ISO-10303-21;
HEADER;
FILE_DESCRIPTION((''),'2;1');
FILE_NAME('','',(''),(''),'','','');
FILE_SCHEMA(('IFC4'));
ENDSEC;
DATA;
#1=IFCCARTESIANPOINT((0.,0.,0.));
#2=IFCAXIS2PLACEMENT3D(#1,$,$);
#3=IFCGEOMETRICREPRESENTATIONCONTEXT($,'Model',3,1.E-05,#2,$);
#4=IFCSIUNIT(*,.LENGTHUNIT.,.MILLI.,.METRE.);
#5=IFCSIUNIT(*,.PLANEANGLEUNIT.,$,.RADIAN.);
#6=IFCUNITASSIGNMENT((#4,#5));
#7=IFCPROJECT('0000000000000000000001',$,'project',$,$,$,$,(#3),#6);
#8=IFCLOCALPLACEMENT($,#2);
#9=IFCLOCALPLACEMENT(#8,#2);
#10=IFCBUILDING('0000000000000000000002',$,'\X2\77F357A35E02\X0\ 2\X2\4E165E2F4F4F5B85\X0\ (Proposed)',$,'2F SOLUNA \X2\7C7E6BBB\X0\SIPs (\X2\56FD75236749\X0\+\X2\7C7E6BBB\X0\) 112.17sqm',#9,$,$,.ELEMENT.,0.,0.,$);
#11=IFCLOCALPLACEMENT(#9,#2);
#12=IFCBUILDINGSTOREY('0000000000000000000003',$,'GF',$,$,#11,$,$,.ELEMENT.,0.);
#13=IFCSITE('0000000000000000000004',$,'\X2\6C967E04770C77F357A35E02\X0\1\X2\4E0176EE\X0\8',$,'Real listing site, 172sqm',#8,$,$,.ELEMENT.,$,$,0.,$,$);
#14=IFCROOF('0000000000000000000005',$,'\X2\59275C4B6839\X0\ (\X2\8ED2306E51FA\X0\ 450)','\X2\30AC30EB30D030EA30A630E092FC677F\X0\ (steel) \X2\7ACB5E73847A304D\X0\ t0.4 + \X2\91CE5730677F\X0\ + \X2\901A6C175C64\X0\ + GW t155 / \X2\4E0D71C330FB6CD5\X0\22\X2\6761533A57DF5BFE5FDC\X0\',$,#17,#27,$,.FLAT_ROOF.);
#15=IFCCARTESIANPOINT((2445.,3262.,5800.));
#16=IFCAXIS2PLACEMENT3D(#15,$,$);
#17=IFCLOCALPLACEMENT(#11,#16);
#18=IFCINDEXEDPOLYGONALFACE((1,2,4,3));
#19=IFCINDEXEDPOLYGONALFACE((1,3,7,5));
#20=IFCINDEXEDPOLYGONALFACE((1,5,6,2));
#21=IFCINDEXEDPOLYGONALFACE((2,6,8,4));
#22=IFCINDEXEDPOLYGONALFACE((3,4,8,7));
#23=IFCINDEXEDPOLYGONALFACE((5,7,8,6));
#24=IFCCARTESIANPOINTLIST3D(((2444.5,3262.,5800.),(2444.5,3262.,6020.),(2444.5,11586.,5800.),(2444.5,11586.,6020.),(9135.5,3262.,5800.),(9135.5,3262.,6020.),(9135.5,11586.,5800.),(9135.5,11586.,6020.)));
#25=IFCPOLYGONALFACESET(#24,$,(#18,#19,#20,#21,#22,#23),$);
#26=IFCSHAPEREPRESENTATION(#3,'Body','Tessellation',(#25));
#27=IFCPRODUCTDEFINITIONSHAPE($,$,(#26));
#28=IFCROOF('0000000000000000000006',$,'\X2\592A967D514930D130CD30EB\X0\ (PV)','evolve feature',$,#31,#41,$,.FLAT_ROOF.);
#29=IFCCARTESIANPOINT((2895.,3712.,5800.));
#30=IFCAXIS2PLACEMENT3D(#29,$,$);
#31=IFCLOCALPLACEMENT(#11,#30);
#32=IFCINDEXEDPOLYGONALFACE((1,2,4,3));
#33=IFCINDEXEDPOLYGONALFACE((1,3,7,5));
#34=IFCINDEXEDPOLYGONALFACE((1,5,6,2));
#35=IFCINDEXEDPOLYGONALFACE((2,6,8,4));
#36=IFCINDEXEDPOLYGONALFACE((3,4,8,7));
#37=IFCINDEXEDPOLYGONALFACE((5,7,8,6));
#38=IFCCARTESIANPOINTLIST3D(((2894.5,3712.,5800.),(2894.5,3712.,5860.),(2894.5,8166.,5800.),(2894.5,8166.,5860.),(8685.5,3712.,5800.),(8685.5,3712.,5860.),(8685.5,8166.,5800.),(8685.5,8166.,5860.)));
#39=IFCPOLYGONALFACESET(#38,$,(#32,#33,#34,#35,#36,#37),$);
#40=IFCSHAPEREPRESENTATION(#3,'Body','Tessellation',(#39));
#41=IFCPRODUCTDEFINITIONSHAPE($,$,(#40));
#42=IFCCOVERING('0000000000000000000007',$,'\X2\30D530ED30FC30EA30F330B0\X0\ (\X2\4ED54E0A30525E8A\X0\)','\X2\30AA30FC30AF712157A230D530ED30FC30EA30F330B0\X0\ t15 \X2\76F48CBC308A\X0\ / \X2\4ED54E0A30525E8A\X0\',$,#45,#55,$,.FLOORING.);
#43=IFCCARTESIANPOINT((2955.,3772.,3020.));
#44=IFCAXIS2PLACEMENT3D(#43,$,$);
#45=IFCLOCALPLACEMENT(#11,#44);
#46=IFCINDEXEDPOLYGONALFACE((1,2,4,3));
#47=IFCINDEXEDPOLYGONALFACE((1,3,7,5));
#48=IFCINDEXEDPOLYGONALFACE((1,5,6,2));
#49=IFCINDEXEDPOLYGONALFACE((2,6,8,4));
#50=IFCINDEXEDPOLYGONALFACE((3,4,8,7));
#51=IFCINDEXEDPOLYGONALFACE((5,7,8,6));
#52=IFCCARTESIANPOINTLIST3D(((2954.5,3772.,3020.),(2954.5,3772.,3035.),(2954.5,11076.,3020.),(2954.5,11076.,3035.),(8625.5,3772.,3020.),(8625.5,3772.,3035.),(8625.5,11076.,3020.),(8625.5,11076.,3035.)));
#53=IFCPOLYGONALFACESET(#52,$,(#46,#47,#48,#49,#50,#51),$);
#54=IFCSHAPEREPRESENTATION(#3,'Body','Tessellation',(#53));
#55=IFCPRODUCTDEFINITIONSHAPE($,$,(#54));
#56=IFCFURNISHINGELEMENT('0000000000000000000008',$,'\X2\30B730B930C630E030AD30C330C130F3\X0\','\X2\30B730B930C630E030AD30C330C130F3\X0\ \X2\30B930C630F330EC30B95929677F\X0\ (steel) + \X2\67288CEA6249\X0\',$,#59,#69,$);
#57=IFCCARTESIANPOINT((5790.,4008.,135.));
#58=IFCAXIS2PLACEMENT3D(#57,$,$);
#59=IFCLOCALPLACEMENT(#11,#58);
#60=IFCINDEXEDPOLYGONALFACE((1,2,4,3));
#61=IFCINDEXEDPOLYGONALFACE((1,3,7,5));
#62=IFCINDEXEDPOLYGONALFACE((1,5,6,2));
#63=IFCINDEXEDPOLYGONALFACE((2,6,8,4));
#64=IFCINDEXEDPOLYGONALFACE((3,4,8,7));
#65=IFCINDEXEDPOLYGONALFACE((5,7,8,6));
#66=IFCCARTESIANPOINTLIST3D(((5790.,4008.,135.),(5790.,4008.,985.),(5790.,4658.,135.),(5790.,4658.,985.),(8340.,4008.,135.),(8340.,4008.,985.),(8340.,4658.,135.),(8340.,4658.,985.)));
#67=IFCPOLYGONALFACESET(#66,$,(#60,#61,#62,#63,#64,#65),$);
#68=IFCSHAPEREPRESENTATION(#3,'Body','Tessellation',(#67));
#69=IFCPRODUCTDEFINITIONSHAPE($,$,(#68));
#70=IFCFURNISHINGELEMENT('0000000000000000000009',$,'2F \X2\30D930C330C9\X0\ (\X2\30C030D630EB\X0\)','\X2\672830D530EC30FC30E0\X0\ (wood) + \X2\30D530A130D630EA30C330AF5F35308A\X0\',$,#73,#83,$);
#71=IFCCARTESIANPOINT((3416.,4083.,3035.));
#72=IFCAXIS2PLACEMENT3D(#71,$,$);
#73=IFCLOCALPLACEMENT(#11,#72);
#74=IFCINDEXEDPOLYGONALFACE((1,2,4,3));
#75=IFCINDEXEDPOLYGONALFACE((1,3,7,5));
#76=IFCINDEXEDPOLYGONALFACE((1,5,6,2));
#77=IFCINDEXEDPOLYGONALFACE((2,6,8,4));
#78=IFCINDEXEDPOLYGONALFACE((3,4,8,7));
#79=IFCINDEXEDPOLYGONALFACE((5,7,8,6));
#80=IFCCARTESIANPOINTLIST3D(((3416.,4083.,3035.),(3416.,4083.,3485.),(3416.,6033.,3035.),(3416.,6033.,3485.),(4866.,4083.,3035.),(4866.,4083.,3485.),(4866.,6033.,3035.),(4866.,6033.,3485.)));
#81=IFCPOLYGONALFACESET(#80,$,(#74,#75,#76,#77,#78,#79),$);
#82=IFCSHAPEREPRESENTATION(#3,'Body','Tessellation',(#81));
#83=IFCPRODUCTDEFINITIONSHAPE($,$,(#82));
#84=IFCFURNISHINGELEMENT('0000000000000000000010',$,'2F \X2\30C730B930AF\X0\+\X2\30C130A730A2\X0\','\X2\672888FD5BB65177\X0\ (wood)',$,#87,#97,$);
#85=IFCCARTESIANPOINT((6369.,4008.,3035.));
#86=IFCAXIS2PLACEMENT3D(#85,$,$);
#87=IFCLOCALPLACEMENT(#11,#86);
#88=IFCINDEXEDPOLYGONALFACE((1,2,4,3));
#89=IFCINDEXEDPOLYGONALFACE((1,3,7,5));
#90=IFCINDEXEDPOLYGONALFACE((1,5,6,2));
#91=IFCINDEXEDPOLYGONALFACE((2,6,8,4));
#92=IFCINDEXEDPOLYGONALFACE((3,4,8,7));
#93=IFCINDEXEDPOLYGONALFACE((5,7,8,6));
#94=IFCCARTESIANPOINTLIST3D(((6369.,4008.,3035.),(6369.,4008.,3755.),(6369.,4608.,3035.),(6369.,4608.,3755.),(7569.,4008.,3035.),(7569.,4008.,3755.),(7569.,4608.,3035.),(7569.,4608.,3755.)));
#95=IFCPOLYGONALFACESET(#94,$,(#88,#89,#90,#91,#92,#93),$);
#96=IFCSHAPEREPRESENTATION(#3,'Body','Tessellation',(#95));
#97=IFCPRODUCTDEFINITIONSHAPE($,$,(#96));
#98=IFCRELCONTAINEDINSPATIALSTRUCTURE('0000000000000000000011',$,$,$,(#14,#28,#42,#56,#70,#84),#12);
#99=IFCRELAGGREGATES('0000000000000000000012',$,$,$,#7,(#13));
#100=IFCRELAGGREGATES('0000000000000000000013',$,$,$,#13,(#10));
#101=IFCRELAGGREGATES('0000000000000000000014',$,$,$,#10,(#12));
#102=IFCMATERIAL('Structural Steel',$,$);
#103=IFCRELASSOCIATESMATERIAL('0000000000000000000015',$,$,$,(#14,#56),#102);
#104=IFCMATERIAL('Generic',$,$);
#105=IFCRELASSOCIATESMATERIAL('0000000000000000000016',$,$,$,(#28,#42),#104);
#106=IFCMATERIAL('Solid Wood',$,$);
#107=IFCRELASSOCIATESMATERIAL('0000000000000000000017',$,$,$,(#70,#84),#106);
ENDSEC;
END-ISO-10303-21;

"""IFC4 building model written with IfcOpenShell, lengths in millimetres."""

from ifc_helpers import new_model, si_unit, frame, frame_2d, origin, place, context, project, spatial, rectangle, extrude, material, element, save


model = new_model("IFC4")

# Units and contexts
model_context = context("Model", 3, precision=1e-05, world=origin())
ifc_project = project(units=[si_unit("LENGTHUNIT", "METRE", prefix="MILLI"), si_unit("PLANEANGLEUNIT", "RADIAN")], contexts=[model_context])

# Site, building, storey
site_placement = place(None, origin())
site = spatial("IfcSite", under=ifc_project, at=site_placement, Name="沖縄県石垣市1丁目8", ObjectType="Real listing site, 172sqm", CompositionType="ELEMENT", RefElevation=0.0)
building_placement = place(site_placement, origin())
building = spatial("IfcBuilding", under=site, at=building_placement, Name="石垣市 2世帯住宅 (Proposed)", ObjectType="2F SOLUNA 籾殻SIPs (国産杉+籾殻) 112.17sqm", CompositionType="ELEMENT", ElevationOfRefHeight=0.0, ElevationOfTerrain=0.0)
storey_placement = place(building_placement, origin())
storey = spatial("IfcBuildingStorey", under=building, at=storey_placement, Name="GF", CompositionType="ELEMENT", Elevation=0.0)

# Shared definitions
ifc_material_1 = material(Name="Solid Wood")

# Shared definitions
ifc_material_2 = material(Name="Generic")

# Roofs
ifc_material_3 = material(Name="Structural Steel")
roof_1_placement = place(storey_placement, frame((2445.0, 3262.0, 5800.0)))
element("IfcRoof", 1, at=roof_1_placement, inside=storey, material=ifc_material_3, Name="大屋根 (軒の出 450)", Description="ガルバリウム鋼板 (steel) 立平葺き t0.4 + 野地板 + 通気層 + GW t155 / 不燃・法22条区域対応", PredefinedType="FLAT_ROOF", context=model_context, shape_type="SweptSolid", body=[
    extrude(rectangle(XDim=6691.0, YDim=8324.0, at=frame_2d((3345.0, 4162.0))), frame((2445.0, 3262.0, 5800.0)), (0.0, 0.0, 1.0), 220.0),
])
roof_2_placement = place(storey_placement, frame((2895.0, 3712.0, 5800.0)))
element("IfcRoof", 2, at=roof_2_placement, inside=storey, material=ifc_material_2, Name="太陽光パネル (PV)", Description="evolve feature", PredefinedType="FLAT_ROOF", context=model_context, shape_type="SweptSolid", body=[
    extrude(rectangle(XDim=5791.0, YDim=4454.0, at=frame_2d((2895.0, 2227.0))), frame((2895.0, 3712.0, 5800.0)), (0.0, 0.0, 1.0), 60.0),
])

# Covering
covering_placement = place(storey_placement, frame((2955.0, 3772.0, 3020.0)))
element("IfcCovering", 3, at=covering_placement, inside=storey, material=ifc_material_2, Name="フローリング (仕上げ床)", Description="オーク無垢フローリング t15 直貼り / 仕上げ床", PredefinedType="FLOORING", context=model_context, shape_type="SweptSolid", body=[
    extrude(rectangle(XDim=5671.0, YDim=7304.0, at=frame_2d((2835.0, 3652.0))), frame((2955.0, 3772.0, 3020.0)), (0.0, 0.0, 1.0), 15.0),
])

# Furnishing elements
furnishing_1_placement = place(storey_placement, frame((5790.0, 4008.0, 135.0)))
element("IfcFurnishingElement", 4, at=furnishing_1_placement, inside=storey, material=ifc_material_3, Name="システムキッチン", Description="システムキッチン ステンレス天板 (steel) + 木質扉", context=model_context, shape_type="SweptSolid", body=[
    extrude(rectangle(XDim=2550.0, YDim=650.0, at=frame_2d((1275.0, 325.0))), frame((5790.0, 4008.0, 135.0)), (0.0, 0.0, 1.0), 850.0),
])
furnishing_2_placement = place(storey_placement, frame((3416.0, 4083.0, 3035.0)))
element("IfcFurnishingElement", 5, at=furnishing_2_placement, inside=storey, material=ifc_material_1, Name="2F ベッド (ダブル)", Description="木フレーム (wood) + ファブリック張り", context=model_context, shape_type="SweptSolid", body=[
    extrude(rectangle(XDim=1450.0, YDim=1950.0, at=frame_2d((725.0, 975.0))), frame((3416.0, 4083.0, 3035.0)), (0.0, 0.0, 1.0), 450.0),
])
furnishing_3_placement = place(storey_placement, frame((6369.0, 4008.0, 3035.0)))
element("IfcFurnishingElement", 6, at=furnishing_3_placement, inside=storey, material=ifc_material_1, Name="2F デスク+チェア", Description="木製家具 (wood)", context=model_context, shape_type="SweptSolid", body=[
    extrude(rectangle(XDim=1200.0, YDim=600.0, at=frame_2d((600.0, 300.0))), frame((6369.0, 4008.0, 3035.0)), (0.0, 0.0, 1.0), 720.0),
])

save(model, "model.ifc")
